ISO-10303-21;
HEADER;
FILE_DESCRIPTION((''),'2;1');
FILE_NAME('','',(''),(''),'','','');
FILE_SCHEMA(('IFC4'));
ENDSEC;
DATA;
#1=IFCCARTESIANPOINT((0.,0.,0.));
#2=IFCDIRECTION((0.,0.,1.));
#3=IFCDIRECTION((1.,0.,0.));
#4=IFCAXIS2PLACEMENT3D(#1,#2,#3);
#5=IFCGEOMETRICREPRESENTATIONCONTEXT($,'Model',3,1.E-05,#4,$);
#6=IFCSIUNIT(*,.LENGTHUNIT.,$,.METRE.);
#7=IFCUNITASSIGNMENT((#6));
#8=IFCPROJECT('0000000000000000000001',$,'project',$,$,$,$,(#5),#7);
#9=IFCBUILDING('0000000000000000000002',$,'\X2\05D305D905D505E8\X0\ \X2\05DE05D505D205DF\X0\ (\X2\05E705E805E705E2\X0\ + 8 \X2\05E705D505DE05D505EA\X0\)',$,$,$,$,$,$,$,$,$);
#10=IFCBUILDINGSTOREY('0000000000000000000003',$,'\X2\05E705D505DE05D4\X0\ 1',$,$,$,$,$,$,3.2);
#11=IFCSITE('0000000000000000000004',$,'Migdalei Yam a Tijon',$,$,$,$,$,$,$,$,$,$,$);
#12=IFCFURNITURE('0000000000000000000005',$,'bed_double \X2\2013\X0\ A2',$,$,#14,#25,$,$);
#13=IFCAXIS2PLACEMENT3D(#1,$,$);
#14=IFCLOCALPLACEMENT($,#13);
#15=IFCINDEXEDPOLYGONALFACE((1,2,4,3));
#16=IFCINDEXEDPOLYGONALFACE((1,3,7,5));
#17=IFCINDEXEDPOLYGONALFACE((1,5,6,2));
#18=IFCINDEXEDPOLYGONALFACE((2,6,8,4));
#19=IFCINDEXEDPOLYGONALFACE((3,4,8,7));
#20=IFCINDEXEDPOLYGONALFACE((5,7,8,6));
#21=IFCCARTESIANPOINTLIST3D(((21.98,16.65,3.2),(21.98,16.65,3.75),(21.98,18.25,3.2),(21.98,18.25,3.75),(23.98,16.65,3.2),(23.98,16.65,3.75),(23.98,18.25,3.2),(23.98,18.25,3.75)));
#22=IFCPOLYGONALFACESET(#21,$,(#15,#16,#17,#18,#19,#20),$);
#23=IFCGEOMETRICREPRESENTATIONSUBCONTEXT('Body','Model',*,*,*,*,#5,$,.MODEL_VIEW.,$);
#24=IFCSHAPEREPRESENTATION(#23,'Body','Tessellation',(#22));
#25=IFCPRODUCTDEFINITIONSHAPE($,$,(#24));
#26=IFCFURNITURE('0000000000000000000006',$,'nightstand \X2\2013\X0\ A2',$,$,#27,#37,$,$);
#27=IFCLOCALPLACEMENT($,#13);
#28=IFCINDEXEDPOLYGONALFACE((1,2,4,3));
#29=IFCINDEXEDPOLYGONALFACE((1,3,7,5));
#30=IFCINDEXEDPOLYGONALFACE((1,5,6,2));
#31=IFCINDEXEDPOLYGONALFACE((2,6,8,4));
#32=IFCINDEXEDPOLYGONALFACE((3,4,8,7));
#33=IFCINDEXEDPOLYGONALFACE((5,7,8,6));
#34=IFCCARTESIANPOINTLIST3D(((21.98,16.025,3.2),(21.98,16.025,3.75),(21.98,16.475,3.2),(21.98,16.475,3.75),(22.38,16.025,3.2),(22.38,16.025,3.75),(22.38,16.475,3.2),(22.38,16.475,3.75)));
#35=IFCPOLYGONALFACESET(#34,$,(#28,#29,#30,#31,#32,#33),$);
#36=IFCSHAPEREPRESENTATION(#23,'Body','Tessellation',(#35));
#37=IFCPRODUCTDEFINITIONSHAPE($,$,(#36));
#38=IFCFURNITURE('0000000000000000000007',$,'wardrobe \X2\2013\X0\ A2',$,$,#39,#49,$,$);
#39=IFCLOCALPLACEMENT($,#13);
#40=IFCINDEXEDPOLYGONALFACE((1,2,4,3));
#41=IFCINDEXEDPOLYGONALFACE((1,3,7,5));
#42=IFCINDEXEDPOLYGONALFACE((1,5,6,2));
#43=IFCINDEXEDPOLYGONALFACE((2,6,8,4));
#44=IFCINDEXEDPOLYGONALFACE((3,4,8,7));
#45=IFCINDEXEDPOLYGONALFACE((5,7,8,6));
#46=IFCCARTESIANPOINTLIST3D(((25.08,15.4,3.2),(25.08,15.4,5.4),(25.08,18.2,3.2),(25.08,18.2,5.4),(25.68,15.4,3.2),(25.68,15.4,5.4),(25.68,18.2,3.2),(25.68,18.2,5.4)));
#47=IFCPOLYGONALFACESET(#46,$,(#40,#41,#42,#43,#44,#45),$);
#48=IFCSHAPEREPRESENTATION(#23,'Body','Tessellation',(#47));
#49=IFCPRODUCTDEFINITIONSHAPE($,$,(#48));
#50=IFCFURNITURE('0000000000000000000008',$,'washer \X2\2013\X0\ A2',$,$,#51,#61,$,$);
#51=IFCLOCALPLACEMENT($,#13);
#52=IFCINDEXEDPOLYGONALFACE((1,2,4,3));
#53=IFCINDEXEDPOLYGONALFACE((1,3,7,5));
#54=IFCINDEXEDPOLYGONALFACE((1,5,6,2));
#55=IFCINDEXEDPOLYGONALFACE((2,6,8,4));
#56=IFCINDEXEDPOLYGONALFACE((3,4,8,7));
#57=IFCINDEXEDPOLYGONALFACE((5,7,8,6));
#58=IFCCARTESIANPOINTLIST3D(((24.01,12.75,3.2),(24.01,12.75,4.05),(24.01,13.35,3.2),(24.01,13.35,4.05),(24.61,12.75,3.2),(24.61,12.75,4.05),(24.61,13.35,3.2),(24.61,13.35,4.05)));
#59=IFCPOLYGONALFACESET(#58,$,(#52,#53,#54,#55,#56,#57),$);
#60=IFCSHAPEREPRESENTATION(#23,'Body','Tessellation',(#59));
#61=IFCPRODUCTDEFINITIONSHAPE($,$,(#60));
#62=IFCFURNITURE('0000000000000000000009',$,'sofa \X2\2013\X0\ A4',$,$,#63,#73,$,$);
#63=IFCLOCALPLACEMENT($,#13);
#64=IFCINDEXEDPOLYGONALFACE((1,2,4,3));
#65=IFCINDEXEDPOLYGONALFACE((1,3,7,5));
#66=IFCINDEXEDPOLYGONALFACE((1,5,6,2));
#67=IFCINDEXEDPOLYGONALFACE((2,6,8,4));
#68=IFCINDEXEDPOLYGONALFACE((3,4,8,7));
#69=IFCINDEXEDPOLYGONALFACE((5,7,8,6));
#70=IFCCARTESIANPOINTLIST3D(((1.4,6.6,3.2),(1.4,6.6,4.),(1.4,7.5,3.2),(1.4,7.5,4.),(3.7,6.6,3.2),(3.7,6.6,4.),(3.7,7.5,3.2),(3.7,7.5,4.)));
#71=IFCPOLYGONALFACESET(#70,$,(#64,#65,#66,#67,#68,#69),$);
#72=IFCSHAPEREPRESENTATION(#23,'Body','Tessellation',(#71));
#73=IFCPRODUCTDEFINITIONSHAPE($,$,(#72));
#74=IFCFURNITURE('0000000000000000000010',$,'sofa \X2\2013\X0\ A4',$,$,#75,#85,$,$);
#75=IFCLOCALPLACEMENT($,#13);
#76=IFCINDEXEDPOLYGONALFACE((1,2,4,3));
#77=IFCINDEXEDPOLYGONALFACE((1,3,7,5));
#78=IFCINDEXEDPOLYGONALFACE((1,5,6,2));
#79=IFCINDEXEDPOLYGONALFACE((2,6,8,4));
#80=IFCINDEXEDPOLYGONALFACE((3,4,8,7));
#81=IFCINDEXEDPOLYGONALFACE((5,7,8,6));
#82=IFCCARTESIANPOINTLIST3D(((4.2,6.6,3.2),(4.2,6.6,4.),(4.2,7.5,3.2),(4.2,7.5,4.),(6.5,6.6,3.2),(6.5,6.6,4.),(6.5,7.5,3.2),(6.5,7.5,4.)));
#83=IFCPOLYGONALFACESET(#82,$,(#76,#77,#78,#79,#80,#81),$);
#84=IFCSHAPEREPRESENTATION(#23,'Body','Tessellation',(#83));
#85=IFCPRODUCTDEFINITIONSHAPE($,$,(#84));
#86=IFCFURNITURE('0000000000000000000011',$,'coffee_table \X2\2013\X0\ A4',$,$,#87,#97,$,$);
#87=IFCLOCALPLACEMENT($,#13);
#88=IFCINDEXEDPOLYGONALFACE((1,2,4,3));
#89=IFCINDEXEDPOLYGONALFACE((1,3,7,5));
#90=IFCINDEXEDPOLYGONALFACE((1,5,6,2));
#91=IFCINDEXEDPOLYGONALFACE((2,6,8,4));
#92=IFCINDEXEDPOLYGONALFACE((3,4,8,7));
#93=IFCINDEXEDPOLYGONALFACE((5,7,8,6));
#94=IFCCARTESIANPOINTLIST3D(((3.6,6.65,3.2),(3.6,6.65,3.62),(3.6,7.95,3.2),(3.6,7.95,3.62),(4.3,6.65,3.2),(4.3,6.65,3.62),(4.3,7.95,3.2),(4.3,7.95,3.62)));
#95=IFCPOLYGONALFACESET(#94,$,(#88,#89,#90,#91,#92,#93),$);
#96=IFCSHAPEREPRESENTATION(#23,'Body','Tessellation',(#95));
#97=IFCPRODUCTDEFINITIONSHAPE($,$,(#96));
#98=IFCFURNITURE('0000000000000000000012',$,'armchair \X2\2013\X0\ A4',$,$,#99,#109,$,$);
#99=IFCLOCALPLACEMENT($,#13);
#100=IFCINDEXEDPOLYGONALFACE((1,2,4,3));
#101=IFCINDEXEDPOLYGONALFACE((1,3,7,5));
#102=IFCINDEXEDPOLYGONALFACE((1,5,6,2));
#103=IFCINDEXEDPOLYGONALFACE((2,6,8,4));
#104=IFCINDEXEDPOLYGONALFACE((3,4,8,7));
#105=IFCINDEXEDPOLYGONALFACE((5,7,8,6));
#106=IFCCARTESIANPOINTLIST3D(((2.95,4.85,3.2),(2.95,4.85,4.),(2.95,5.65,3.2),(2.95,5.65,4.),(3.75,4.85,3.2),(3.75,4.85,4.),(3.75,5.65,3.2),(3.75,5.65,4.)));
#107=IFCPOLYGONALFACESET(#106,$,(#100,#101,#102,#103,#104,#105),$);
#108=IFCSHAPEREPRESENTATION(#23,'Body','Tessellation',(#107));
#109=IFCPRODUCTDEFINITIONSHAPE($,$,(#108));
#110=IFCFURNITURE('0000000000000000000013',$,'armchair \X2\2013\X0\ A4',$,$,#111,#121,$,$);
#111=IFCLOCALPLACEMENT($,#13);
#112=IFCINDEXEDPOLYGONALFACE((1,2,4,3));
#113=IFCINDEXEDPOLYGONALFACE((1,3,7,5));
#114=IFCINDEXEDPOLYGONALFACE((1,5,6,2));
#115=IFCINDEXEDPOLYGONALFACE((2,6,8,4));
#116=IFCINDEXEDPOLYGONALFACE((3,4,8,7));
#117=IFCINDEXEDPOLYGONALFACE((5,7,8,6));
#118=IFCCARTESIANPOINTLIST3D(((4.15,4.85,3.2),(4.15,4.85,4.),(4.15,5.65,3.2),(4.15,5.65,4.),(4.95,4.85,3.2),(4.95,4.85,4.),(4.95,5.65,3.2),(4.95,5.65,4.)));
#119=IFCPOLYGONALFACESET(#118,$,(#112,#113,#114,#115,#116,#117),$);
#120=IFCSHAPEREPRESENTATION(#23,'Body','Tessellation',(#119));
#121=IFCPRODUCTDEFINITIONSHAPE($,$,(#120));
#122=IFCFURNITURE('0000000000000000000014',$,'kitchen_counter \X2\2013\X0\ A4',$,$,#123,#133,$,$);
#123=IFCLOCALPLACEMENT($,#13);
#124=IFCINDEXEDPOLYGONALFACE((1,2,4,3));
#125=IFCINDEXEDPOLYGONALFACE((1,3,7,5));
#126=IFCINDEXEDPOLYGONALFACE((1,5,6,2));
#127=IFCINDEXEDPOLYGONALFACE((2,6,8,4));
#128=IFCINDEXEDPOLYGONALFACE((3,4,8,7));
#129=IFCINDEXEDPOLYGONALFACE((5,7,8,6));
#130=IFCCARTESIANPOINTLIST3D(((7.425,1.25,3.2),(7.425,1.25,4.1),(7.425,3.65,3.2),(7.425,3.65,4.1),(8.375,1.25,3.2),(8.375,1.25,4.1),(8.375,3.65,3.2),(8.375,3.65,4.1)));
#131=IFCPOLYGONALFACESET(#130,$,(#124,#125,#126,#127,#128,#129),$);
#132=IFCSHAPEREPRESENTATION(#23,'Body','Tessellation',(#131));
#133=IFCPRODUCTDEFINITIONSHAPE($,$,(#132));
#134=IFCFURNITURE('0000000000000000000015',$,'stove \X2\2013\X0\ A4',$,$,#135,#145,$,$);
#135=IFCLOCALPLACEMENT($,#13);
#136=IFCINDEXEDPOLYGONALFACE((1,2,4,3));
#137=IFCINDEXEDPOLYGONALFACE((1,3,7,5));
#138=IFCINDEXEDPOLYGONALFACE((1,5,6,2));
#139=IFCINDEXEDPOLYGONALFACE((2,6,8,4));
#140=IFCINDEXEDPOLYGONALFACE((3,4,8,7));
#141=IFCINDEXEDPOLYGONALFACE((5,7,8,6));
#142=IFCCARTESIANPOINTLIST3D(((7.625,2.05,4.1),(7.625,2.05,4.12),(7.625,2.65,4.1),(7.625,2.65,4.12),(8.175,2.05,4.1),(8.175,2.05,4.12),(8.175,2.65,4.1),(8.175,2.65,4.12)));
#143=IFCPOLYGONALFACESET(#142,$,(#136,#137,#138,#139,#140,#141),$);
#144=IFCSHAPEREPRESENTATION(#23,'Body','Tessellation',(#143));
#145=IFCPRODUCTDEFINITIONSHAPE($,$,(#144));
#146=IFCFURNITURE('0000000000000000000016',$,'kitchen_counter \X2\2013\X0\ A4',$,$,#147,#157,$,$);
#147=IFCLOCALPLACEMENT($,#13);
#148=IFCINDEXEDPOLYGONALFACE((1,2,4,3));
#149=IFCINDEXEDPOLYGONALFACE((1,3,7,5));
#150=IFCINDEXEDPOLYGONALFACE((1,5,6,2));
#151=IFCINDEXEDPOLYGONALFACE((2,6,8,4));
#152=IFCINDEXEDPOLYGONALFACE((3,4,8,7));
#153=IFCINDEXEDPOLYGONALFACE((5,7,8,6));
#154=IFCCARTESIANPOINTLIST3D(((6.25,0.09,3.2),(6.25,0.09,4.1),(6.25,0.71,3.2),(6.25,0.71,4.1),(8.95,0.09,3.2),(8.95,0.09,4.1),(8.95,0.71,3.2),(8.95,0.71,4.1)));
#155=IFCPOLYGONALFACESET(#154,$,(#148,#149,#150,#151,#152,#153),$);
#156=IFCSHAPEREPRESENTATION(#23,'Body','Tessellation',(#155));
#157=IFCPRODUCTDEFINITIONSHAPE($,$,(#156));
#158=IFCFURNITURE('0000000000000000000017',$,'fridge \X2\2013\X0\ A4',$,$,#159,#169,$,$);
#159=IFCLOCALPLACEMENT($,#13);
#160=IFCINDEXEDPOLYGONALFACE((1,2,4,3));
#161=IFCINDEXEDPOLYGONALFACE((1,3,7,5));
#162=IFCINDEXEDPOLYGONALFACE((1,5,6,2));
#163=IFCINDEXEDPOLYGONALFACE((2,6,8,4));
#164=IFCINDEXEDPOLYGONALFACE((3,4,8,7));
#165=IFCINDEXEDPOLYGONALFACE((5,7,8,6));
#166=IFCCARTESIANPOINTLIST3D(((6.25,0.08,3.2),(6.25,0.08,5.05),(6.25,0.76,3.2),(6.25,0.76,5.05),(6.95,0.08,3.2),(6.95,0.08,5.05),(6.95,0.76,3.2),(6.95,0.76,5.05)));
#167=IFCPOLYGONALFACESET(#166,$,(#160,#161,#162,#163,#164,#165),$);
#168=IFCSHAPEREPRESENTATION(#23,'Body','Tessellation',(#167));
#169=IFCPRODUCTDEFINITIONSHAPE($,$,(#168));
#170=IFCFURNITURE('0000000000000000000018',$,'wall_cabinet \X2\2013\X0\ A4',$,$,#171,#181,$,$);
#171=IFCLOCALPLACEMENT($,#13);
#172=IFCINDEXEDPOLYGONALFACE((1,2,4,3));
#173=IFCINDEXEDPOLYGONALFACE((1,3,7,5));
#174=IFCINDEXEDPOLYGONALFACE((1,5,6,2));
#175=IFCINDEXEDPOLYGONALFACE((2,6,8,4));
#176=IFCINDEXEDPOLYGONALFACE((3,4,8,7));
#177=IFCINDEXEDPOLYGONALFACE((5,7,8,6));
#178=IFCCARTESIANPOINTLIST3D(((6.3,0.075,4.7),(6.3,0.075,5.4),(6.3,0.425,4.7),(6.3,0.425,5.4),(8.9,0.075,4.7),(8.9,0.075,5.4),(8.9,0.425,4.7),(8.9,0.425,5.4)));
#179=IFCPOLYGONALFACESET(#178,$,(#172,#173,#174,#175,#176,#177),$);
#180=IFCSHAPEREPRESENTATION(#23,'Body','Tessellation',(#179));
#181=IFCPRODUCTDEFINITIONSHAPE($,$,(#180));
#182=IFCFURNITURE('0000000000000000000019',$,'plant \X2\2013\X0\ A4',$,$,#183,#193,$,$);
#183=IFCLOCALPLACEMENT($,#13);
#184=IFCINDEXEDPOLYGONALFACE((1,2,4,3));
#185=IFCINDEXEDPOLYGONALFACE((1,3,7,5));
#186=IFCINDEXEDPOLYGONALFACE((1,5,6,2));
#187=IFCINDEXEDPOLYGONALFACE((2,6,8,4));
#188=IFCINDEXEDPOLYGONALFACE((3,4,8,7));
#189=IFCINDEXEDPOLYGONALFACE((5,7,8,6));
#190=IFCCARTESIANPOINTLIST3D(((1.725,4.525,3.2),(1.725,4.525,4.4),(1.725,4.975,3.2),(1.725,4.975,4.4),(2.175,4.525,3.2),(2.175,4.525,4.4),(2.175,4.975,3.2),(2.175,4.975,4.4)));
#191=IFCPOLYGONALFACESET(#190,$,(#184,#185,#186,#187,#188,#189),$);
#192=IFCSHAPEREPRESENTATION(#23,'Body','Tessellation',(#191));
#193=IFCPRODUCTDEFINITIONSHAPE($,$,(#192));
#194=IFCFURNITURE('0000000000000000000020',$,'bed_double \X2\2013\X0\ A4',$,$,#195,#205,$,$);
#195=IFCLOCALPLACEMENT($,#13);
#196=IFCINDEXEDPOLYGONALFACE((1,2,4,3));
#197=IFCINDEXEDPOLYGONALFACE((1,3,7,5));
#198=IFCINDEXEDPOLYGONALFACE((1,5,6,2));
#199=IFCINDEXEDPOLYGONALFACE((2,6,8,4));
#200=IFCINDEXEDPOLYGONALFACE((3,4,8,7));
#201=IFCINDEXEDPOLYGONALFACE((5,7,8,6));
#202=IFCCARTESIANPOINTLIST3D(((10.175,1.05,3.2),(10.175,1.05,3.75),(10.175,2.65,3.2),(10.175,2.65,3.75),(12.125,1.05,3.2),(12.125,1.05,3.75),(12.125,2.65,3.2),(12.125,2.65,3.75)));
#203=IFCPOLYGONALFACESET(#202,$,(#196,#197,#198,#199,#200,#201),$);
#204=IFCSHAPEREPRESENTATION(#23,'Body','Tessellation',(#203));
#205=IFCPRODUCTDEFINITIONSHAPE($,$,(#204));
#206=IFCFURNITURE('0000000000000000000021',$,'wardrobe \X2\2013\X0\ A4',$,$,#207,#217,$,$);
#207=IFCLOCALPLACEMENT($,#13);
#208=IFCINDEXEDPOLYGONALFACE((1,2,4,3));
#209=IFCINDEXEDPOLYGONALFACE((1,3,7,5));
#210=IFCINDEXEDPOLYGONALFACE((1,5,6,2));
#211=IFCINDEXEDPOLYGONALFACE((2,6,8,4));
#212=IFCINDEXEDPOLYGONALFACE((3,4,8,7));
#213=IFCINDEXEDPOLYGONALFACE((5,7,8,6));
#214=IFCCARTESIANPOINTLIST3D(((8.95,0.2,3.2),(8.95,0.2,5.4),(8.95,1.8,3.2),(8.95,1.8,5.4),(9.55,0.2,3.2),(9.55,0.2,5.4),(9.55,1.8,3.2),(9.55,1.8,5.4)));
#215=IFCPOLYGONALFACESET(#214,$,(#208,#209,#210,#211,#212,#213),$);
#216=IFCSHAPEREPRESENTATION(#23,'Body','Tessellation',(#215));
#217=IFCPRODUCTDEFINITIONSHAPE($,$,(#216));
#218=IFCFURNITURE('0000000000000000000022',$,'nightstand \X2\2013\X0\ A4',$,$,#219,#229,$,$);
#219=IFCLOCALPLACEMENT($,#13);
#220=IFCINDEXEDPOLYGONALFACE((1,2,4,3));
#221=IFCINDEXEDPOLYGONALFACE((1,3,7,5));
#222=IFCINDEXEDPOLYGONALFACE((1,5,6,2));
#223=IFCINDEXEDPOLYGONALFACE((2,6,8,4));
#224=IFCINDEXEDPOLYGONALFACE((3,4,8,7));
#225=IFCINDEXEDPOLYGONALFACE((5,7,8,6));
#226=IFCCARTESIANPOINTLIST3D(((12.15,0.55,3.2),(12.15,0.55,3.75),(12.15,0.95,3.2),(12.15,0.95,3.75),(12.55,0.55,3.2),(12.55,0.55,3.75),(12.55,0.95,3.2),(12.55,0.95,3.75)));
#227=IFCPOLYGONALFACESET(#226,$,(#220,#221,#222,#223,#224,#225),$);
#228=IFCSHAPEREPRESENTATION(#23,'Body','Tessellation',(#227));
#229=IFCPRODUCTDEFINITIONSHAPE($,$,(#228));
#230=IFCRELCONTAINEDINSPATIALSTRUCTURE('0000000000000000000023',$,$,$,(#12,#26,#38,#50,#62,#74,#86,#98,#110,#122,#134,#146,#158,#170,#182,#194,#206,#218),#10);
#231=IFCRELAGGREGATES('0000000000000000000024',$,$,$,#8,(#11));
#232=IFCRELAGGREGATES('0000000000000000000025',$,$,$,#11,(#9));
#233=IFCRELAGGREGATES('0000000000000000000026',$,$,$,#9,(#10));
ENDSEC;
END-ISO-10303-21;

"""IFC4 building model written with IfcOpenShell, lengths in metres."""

from ifc_helpers import new_model, si_unit, frame, origin_with_axes, context, subcontext, project, spatial, line, indexed_curve, outline, extrude, element, save


model = new_model("IFC4")

# Units and contexts
model_context = context("Model", 3, precision=1e-05, world=origin_with_axes())
body_context = subcontext(model_context, "Body", "Model", "MODEL_VIEW")
ifc_project = project(units=[si_unit("LENGTHUNIT", "METRE")], contexts=[model_context])

# Site, building, storey
site = spatial("IfcSite", under=ifc_project, Name="Migdalei Yam a Tijon")
building = spatial("IfcBuilding", under=site, Name="דיור מוגן (קרקע + 8 קומות)")
storey = spatial("IfcBuildingStorey", under=building, Name="קומה 1", Elevation=3.2)

# Furniture
element("IfcFurniture", 1, inside=storey, Name="bed_double – A2", context=body_context, shape_type="SweptSolid", body=[
    extrude(outline(indexed_curve([(0.0, 0.0), (2.0, 0.0), (2.0, 1.6), (0.0, 1.6)], segments=[line(1, 2, 3, 4, 1)])), frame((21.98, 16.65, 3.2), z_axis=(0.0, 0.0, 1.0), x_axis=(1.0, 0.0, 0.0)), (0.0, 0.0, 1.0), 0.55),
])
element("IfcFurniture", 2, inside=storey, Name="nightstand – A2", context=body_context, shape_type="SweptSolid", body=[
    extrude(outline(indexed_curve([(0.0, 0.0), (0.4, 0.0), (0.4, 0.45), (0.0, 0.45)], segments=[line(1, 2, 3, 4, 1)])), frame((21.98, 16.025, 3.2), z_axis=(0.0, 0.0, 1.0), x_axis=(1.0, 0.0, 0.0)), (0.0, 0.0, 1.0), 0.55),
])
element("IfcFurniture", 3, inside=storey, Name="wardrobe – A2", context=body_context, shape_type="SweptSolid", body=[
    extrude(outline(indexed_curve([(0.0, 0.0), (0.6, 0.0), (0.6, 2.8), (0.0, 2.8)], segments=[line(1, 2, 3, 4, 1)])), frame((25.08, 15.4, 3.2), z_axis=(0.0, 0.0, 1.0), x_axis=(1.0, 0.0, 0.0)), (0.0, 0.0, 1.0), 2.2),
])
element("IfcFurniture", 4, inside=storey, Name="washer – A2", context=body_context, shape_type="SweptSolid", body=[
    extrude(outline(indexed_curve([(0.0, 0.0), (0.6, 0.0), (0.6, 0.6), (0.0, 0.6)], segments=[line(1, 2, 3, 4, 1)])), frame((24.01, 12.75, 3.2), z_axis=(0.0, 0.0, 1.0), x_axis=(1.0, 0.0, 0.0)), (0.0, 0.0, 1.0), 0.85),
])
element("IfcFurniture", 5, inside=storey, Name="sofa – A4", context=body_context, shape_type="SweptSolid", body=[
    extrude(outline(indexed_curve([(0.0, 0.0), (2.3, 0.0), (2.3, 0.9), (0.0, 0.9)], segments=[line(1, 2, 3, 4, 1)])), frame((1.4, 6.6, 3.2), z_axis=(0.0, 0.0, 1.0), x_axis=(1.0, 0.0, 0.0)), (0.0, 0.0, 1.0), 0.8),
])
element("IfcFurniture", 6, inside=storey, Name="sofa – A4", context=body_context, shape_type="SweptSolid", body=[
    extrude(outline(indexed_curve([(0.0, 0.0), (2.3, 0.0), (2.3, 0.9), (0.0, 0.9)], segments=[line(1, 2, 3, 4, 1)])), frame((4.2, 6.6, 3.2), z_axis=(0.0, 0.0, 1.0), x_axis=(1.0, 0.0, 0.0)), (0.0, 0.0, 1.0), 0.8),
])
element("IfcFurniture", 7, inside=storey, Name="coffee_table – A4", context=body_context, shape_type="SweptSolid", body=[
    extrude(outline(indexed_curve([(0.0, 0.0), (0.7, 0.0), (0.7, 1.3), (0.0, 1.3)], segments=[line(1, 2, 3, 4, 1)])), frame((3.6, 6.65, 3.2), z_axis=(0.0, 0.0, 1.0), x_axis=(1.0, 0.0, 0.0)), (0.0, 0.0, 1.0), 0.42),
])
element("IfcFurniture", 8, inside=storey, Name="armchair – A4", context=body_context, shape_type="SweptSolid", body=[
    extrude(outline(indexed_curve([(0.0, 0.0), (0.8, 0.0), (0.8, 0.8), (0.0, 0.8)], segments=[line(1, 2, 3, 4, 1)])), frame((2.95, 4.85, 3.2), z_axis=(0.0, 0.0, 1.0), x_axis=(1.0, 0.0, 0.0)), (0.0, 0.0, 1.0), 0.8),
])
element("IfcFurniture", 9, inside=storey, Name="armchair – A4", context=body_context, shape_type="SweptSolid", body=[
    extrude(outline(indexed_curve([(0.0, 0.0), (0.8, 0.0), (0.8, 0.8), (0.0, 0.8)], segments=[line(1, 2, 3, 4, 1)])), frame((4.15, 4.85, 3.2), z_axis=(0.0, 0.0, 1.0), x_axis=(1.0, 0.0, 0.0)), (0.0, 0.0, 1.0), 0.8),
])
element("IfcFurniture", 10, inside=storey, Name="kitchen_counter – A4", context=body_context, shape_type="SweptSolid", body=[
    extrude(outline(indexed_curve([(0.0, 0.0), (0.95, 0.0), (0.95, 2.4), (0.0, 2.4)], segments=[line(1, 2, 3, 4, 1)])), frame((7.425, 1.25, 3.2), z_axis=(0.0, 0.0, 1.0), x_axis=(1.0, 0.0, 0.0)), (0.0, 0.0, 1.0), 0.9),
])
element("IfcFurniture", 11, inside=storey, Name="stove – A4", context=body_context, shape_type="SweptSolid", body=[
    extrude(outline(indexed_curve([(0.0, 0.0), (0.55, 0.0), (0.55, 0.6), (0.0, 0.6)], segments=[line(1, 2, 3, 4, 1)])), frame((7.625, 2.05, 4.1), z_axis=(0.0, 0.0, 1.0), x_axis=(1.0, 0.0, 0.0)), (0.0, 0.0, 1.0), 0.02),
])
element("IfcFurniture", 12, inside=storey, Name="kitchen_counter – A4", context=body_context, shape_type="SweptSolid", body=[
    extrude(outline(indexed_curve([(0.0, 0.0), (2.7, 0.0), (2.7, 0.62), (0.0, 0.62)], segments=[line(1, 2, 3, 4, 1)])), frame((6.25, 0.09, 3.2), z_axis=(0.0, 0.0, 1.0), x_axis=(1.0, 0.0, 0.0)), (0.0, 0.0, 1.0), 0.9),
])
element("IfcFurniture", 13, inside=storey, Name="fridge – A4", context=body_context, shape_type="SweptSolid", body=[
    extrude(outline(indexed_curve([(0.0, 0.0), (0.7, 0.0), (0.7, 0.68), (0.0, 0.68)], segments=[line(1, 2, 3, 4, 1)])), frame((6.25, 0.08, 3.2), z_axis=(0.0, 0.0, 1.0), x_axis=(1.0, 0.0, 0.0)), (0.0, 0.0, 1.0), 1.85),
])
element("IfcFurniture", 14, inside=storey, Name="wall_cabinet – A4", context=body_context, shape_type="SweptSolid", body=[
    extrude(outline(indexed_curve([(0.0, 0.0), (2.6, 0.0), (2.6, 0.35), (0.0, 0.35)], segments=[line(1, 2, 3, 4, 1)])), frame((6.3, 0.075, 4.7), z_axis=(0.0, 0.0, 1.0), x_axis=(1.0, 0.0, 0.0)), (0.0, 0.0, 1.0), 0.7),
])
element("IfcFurniture", 15, inside=storey, Name="plant – A4", context=body_context, shape_type="SweptSolid", body=[
    extrude(outline(indexed_curve([(0.0, 0.0), (0.45, 0.0), (0.45, 0.45), (0.0, 0.45)], segments=[line(1, 2, 3, 4, 1)])), frame((1.725, 4.525, 3.2), z_axis=(0.0, 0.0, 1.0), x_axis=(1.0, 0.0, 0.0)), (0.0, 0.0, 1.0), 1.2),
])
element("IfcFurniture", 16, inside=storey, Name="bed_double – A4", context=body_context, shape_type="SweptSolid", body=[
    extrude(outline(indexed_curve([(0.0, 0.0), (1.95, 0.0), (1.95, 1.6), (0.0, 1.6)], segments=[line(1, 2, 3, 4, 1)])), frame((10.175, 1.05, 3.2), z_axis=(0.0, 0.0, 1.0), x_axis=(1.0, 0.0, 0.0)), (0.0, 0.0, 1.0), 0.55),
])
element("IfcFurniture", 17, inside=storey, Name="wardrobe – A4", context=body_context, shape_type="SweptSolid", body=[
    extrude(outline(indexed_curve([(0.0, 0.0), (0.6, 0.0), (0.6, 1.6), (0.0, 1.6)], segments=[line(1, 2, 3, 4, 1)])), frame((8.95, 0.2, 3.2), z_axis=(0.0, 0.0, 1.0), x_axis=(1.0, 0.0, 0.0)), (0.0, 0.0, 1.0), 2.2),
])
element("IfcFurniture", 18, inside=storey, Name="nightstand – A4", context=body_context, shape_type="SweptSolid", body=[
    extrude(outline(indexed_curve([(0.0, 0.0), (0.4, 0.0), (0.4, 0.4), (0.0, 0.4)], segments=[line(1, 2, 3, 4, 1)])), frame((12.15, 0.55, 3.2), z_axis=(0.0, 0.0, 1.0), x_axis=(1.0, 0.0, 0.0)), (0.0, 0.0, 1.0), 0.55),
])

save(model, "model.ifc")
